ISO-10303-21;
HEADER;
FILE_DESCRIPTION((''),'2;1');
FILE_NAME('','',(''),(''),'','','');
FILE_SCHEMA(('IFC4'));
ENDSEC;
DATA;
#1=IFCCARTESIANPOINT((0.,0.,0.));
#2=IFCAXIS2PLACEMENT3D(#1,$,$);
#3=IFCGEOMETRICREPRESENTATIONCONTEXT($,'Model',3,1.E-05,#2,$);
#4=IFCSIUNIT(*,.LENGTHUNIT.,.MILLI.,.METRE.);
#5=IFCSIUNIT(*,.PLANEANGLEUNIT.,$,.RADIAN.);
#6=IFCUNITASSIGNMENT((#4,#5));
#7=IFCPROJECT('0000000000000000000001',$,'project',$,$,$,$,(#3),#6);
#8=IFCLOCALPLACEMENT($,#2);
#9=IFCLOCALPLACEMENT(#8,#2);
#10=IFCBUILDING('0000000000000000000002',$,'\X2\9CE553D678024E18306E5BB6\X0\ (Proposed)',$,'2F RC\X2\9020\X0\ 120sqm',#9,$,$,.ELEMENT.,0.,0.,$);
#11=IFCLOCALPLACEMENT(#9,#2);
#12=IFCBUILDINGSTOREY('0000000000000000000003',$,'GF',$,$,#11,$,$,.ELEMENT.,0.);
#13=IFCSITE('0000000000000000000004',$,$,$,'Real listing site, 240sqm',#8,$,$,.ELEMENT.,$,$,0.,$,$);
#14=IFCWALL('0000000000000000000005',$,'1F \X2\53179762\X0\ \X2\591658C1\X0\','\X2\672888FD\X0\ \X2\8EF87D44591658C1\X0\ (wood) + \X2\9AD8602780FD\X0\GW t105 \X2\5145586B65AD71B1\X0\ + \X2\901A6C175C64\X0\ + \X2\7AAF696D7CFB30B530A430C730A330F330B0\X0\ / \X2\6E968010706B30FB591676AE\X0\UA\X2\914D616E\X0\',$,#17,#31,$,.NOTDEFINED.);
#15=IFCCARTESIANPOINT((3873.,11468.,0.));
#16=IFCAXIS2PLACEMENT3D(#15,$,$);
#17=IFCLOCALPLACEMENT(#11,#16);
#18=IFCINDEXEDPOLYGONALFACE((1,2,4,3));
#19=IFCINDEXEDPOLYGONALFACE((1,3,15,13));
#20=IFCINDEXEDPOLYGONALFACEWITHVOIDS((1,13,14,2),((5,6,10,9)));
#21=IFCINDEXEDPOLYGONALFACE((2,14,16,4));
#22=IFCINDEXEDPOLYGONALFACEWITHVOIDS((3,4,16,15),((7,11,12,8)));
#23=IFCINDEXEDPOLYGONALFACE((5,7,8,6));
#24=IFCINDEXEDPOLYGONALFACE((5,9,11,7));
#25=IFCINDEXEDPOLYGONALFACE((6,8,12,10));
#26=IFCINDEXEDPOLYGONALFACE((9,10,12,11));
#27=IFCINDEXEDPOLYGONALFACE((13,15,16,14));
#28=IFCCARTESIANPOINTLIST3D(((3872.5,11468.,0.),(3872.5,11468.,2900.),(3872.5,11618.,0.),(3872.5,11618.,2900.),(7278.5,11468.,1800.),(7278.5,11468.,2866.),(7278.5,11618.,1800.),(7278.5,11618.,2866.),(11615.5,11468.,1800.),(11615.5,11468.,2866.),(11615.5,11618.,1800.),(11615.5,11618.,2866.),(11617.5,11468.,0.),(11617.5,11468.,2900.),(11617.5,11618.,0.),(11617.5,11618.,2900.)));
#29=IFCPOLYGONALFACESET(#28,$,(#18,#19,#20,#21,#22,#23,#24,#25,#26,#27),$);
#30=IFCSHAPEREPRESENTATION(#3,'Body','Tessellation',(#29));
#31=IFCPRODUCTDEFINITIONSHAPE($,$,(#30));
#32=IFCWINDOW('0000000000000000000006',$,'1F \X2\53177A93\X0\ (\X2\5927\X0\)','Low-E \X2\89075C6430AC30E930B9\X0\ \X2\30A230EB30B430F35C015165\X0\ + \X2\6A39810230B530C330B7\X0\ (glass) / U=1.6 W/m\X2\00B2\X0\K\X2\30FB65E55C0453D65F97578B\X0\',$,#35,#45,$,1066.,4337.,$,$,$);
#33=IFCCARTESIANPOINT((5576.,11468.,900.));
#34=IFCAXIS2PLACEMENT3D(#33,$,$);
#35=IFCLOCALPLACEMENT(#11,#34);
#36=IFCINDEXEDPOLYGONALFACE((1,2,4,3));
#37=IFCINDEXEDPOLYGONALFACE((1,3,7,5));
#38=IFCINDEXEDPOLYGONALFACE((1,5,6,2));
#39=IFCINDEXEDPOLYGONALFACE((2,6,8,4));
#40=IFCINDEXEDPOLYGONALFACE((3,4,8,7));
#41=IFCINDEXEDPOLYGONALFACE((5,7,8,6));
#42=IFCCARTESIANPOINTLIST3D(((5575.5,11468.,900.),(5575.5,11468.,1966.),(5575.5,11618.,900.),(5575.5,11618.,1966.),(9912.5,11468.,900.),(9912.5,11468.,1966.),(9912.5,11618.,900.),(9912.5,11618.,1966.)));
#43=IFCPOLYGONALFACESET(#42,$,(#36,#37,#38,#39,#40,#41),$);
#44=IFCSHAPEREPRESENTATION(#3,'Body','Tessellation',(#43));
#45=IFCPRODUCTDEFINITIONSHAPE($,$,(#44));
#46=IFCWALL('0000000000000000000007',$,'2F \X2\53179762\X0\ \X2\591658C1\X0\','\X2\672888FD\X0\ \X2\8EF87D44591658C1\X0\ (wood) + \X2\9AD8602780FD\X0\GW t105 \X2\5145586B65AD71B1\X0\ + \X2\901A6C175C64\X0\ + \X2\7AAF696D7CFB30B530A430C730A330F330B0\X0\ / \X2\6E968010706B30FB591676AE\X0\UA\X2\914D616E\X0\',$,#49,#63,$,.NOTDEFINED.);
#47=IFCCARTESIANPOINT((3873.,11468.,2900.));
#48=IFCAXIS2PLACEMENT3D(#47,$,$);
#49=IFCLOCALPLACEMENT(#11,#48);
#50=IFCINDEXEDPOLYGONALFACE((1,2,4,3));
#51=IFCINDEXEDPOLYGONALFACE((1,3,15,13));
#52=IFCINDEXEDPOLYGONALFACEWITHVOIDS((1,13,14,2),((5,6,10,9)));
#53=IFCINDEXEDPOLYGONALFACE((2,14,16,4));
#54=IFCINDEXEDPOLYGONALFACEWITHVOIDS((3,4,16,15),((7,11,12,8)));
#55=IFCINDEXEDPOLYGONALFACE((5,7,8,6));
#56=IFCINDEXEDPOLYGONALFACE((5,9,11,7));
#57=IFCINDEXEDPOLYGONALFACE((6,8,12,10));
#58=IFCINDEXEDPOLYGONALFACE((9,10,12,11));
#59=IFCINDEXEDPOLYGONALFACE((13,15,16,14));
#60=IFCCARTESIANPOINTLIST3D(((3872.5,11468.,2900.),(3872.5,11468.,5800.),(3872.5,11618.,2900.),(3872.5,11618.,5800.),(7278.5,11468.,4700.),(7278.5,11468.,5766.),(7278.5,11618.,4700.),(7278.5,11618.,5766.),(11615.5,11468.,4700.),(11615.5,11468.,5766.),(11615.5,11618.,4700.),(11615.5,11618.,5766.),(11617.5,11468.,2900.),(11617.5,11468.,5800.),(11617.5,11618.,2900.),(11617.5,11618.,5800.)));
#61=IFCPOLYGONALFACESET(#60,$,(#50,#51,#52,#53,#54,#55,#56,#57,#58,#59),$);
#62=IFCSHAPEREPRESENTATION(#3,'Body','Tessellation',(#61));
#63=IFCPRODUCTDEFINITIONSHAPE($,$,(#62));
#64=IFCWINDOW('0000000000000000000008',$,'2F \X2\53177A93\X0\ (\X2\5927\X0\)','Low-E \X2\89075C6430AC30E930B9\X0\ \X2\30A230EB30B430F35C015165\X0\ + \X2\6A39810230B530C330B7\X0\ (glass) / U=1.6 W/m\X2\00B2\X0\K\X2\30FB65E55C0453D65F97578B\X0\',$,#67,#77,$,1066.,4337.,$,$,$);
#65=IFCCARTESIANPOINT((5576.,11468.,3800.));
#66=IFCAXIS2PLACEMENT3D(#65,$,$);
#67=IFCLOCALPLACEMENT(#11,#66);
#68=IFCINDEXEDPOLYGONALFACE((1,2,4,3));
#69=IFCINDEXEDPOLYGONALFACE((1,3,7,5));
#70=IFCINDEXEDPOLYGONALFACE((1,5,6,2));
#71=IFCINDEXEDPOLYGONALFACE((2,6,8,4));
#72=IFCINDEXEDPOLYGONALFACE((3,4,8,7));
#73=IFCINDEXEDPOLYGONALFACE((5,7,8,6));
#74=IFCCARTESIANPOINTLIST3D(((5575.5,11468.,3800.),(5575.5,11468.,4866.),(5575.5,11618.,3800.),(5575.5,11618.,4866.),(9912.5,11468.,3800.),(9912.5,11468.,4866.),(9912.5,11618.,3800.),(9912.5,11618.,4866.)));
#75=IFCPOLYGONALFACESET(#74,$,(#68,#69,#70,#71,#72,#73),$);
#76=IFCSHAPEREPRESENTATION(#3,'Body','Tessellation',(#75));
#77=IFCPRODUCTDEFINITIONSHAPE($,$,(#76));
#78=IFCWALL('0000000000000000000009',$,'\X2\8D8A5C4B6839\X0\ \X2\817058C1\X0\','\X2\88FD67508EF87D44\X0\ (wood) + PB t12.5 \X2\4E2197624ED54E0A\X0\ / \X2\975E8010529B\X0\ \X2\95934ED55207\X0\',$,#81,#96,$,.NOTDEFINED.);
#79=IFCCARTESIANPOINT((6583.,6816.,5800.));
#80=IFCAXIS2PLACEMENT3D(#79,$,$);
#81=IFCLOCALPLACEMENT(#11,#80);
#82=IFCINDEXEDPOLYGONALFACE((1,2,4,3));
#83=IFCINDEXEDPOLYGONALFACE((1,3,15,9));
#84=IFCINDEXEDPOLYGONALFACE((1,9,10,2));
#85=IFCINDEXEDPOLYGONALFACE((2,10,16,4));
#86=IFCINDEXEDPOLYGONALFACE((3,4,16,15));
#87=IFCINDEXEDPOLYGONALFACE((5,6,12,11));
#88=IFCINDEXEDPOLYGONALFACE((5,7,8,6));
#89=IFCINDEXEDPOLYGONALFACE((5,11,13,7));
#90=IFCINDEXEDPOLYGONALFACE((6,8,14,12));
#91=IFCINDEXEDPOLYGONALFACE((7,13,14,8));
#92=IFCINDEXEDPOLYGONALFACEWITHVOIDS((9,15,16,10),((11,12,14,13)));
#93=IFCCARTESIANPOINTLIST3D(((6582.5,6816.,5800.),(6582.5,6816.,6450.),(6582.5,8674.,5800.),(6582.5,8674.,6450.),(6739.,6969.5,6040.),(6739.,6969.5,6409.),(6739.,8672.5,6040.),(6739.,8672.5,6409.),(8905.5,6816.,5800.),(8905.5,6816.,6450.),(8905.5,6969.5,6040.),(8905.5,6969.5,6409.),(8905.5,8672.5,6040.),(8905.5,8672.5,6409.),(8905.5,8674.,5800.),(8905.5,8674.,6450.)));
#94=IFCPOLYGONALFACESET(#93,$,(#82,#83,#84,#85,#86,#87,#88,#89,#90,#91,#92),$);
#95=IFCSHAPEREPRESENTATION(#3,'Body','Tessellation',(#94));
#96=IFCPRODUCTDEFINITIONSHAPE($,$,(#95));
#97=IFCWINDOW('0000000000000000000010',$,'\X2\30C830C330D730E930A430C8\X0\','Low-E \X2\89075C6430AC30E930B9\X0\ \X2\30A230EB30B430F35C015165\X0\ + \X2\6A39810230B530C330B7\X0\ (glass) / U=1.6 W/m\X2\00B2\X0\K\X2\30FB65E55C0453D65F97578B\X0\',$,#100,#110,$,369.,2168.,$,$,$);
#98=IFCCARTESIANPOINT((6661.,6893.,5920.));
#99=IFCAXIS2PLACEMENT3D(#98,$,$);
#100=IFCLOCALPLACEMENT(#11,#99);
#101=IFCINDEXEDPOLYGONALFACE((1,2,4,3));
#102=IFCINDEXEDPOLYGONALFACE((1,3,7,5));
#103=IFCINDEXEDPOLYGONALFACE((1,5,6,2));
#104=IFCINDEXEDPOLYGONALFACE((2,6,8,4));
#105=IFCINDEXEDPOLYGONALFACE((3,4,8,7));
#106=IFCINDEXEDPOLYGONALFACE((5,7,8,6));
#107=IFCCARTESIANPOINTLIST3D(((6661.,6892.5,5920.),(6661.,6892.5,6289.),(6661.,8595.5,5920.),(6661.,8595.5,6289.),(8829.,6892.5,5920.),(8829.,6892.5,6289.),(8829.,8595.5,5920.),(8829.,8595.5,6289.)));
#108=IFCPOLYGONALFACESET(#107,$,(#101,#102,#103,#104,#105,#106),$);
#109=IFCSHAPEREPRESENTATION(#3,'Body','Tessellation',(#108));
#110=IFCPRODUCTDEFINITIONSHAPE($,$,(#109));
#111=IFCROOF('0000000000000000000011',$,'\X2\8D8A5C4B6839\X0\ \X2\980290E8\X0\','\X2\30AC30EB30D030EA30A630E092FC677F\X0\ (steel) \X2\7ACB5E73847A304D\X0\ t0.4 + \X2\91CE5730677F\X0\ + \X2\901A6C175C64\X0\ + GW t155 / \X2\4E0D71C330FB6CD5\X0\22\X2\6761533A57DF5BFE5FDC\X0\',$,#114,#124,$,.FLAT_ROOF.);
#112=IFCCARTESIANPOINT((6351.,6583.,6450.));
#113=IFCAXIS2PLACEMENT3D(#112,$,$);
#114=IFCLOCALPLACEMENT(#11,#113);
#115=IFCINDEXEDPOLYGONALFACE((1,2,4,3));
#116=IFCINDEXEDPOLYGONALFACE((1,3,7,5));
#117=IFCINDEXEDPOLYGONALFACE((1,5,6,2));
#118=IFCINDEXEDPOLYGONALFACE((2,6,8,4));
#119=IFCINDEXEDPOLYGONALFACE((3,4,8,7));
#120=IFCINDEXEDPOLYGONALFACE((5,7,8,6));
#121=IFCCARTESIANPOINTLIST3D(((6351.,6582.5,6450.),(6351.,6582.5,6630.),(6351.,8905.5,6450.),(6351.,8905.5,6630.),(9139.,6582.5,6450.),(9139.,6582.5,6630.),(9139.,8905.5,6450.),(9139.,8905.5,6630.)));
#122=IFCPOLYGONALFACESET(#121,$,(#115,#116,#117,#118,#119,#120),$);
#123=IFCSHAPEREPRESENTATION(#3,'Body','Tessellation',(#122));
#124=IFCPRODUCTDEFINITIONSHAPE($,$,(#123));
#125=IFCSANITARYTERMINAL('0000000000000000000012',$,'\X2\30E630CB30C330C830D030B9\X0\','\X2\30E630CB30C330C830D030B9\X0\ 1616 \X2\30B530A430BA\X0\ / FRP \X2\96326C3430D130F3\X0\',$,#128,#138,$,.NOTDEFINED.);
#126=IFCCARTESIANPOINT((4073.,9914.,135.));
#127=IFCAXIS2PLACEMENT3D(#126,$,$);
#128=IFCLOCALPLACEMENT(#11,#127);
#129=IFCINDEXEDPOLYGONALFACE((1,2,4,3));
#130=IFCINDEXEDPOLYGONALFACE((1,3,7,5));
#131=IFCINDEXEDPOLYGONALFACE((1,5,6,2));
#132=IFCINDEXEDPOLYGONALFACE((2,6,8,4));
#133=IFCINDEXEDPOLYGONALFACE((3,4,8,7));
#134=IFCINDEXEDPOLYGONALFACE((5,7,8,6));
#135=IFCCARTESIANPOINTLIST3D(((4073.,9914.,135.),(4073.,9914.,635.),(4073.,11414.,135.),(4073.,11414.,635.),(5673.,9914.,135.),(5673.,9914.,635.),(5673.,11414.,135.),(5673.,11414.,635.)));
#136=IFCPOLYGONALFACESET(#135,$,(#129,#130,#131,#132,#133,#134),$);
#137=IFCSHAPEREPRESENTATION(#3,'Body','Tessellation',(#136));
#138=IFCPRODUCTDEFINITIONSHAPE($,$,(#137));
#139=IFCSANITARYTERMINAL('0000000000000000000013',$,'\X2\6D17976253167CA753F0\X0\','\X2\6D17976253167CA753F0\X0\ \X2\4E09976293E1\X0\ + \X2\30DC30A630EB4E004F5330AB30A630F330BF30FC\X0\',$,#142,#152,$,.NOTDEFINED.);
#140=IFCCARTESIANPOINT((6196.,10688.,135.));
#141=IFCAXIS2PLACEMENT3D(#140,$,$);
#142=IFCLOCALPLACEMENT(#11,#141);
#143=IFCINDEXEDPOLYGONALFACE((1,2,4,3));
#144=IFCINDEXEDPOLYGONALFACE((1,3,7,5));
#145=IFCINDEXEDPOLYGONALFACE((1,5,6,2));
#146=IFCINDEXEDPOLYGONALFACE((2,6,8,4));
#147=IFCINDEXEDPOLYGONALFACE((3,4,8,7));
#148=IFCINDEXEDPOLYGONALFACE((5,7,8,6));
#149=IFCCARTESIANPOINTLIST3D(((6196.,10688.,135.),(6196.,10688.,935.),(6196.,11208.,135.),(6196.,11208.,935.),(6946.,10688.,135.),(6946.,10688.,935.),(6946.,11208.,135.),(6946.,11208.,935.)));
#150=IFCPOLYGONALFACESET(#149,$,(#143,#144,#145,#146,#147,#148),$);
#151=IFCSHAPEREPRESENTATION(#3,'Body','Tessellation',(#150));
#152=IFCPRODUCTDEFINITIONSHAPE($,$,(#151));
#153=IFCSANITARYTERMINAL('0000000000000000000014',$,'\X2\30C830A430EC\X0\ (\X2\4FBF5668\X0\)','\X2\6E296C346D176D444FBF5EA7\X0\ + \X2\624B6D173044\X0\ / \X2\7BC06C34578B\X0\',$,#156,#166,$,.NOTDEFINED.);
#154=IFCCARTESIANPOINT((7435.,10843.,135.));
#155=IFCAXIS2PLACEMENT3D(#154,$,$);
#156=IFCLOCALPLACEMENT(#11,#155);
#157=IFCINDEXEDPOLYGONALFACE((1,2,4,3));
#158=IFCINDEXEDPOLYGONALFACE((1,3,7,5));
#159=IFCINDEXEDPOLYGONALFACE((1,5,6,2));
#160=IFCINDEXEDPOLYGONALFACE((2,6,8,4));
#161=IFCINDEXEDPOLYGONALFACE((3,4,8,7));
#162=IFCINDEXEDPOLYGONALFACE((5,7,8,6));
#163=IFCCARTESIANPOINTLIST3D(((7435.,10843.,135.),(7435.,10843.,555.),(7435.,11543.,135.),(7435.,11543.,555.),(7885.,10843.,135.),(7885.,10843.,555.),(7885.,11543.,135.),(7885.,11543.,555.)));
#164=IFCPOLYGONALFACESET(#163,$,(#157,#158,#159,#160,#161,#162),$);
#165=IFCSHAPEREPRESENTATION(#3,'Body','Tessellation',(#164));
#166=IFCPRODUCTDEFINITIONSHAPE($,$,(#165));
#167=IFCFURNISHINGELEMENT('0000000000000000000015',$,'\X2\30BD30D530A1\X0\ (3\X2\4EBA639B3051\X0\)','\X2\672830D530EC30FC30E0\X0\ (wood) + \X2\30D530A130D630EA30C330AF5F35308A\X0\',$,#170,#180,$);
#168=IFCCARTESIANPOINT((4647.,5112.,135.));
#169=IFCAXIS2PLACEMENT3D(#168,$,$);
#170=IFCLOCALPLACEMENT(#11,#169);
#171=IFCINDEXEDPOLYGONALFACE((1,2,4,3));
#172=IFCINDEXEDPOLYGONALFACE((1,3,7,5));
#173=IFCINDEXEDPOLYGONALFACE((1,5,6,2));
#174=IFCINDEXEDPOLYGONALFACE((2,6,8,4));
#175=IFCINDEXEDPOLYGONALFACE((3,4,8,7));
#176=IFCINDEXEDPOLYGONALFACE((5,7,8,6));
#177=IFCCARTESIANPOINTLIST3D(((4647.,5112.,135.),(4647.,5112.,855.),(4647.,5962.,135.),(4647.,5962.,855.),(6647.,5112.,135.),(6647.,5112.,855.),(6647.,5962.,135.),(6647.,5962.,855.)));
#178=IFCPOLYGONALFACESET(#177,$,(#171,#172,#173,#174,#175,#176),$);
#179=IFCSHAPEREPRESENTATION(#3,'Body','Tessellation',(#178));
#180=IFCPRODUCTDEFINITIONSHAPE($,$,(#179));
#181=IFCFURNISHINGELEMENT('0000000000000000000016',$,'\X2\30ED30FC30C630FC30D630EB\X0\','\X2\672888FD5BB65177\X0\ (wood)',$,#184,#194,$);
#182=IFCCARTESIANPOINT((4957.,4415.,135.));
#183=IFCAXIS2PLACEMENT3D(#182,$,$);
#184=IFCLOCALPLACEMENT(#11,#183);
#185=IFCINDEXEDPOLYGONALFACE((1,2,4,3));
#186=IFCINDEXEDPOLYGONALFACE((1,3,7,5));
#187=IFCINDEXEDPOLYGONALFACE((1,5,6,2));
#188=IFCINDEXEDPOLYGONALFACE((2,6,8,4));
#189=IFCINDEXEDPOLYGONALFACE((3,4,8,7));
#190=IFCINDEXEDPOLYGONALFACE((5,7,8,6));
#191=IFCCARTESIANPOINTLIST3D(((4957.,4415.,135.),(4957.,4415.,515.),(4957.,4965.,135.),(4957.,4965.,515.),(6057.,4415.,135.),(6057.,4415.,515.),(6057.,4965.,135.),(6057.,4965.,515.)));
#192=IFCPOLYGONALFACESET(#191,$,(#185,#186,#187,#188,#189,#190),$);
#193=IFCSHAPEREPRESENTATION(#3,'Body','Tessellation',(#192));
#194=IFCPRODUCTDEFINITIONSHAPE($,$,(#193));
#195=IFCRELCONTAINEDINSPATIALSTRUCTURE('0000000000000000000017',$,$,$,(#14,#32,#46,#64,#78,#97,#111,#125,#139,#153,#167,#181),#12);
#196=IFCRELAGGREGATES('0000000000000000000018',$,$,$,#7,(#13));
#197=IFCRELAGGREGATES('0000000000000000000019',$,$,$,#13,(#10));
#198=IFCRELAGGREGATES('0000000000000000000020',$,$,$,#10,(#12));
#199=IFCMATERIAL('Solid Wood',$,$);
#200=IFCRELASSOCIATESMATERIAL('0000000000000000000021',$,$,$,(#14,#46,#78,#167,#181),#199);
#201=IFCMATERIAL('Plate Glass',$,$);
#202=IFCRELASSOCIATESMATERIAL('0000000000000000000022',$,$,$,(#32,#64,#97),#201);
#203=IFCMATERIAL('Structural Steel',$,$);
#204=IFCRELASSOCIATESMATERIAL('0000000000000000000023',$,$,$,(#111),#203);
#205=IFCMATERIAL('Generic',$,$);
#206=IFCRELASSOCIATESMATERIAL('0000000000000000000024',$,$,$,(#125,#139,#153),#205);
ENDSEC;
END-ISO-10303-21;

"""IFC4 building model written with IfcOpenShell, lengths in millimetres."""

from ifc_helpers import new_model, si_unit, frame, frame_2d, origin, place, context, project, spatial, rectangle, extrude, material, element, fill, save


model = new_model("IFC4")

# Units and contexts
model_context = context("Model", 3, precision=1e-05, world=origin())
ifc_project = project(units=[si_unit("LENGTHUNIT", "METRE", prefix="MILLI"), si_unit("PLANEANGLEUNIT", "RADIAN")], contexts=[model_context])

# Site, building, storey
site_placement = place(None, origin())
site = spatial("IfcSite", under=ifc_project, at=site_placement, ObjectType="Real listing site, 240sqm", CompositionType="ELEMENT", RefElevation=0.0)
building_placement = place(site_placement, origin())
building = spatial("IfcBuilding", under=site, at=building_placement, Name="鳥取砂丘の家 (Proposed)", ObjectType="2F RC造 120sqm", CompositionType="ELEMENT", ElevationOfRefHeight=0.0, ElevationOfTerrain=0.0)
storey_placement = place(building_placement, origin())
storey = spatial("IfcBuildingStorey", under=building, at=storey_placement, Name="GF", CompositionType="ELEMENT", Elevation=0.0)

# Wall, opening, window
ifc_material_1 = material(Name="Solid Wood")
wall_1_placement = place(storey_placement, frame((3873.0, 11468.0, 0.0)))
wall_1 = element("IfcWall", 1, at=wall_1_placement, inside=storey, material=ifc_material_1, Name="1F 北面 外壁", Description="木製 軸組外壁 (wood) + 高性能GW t105 充填断熱 + 通気層 + 窯業系サイディング / 準耐火・外皮UA配慮", PredefinedType="NOTDEFINED", context=model_context, shape_type="SweptSolid", body=[
    extrude(rectangle(XDim=7745.0, YDim=150.0, at=frame_2d((3872.0, 75.0))), frame((3873.0, 11468.0, 0.0)), (0.0, 0.0, 1.0), 2900.0),
])
opening_1_placement = place(storey_placement, frame((5576.0, 11468.0, 900.0)))
opening_1 = element("IfcOpeningElement", 2, at=opening_1_placement, cuts=wall_1, PredefinedType="NOTDEFINED", context=model_context, shape_type="SweptSolid", body=[
    extrude(rectangle(XDim=4337.0, YDim=150.0, at=frame_2d((2168.0, 75.0))), frame((5576.0, 11468.0, 900.0)), (0.0, 0.0, 1.0), 1066.0),
])
ifc_material_2 = material(Name="Plate Glass")
window_1_placement = place(storey_placement, frame((5576.0, 11468.0, 900.0)))
window_1 = element("IfcWindow", 3, at=window_1_placement, inside=storey, material=ifc_material_2, Name="1F 北窓 (大)", Description="Low-E 複層ガラス アルゴン封入 + 樹脂サッシ (glass) / U=1.6 W/m²K・日射取得型", OverallHeight=1066.0, OverallWidth=4337.0, context=model_context, shape_type="SweptSolid", body=[
    extrude(rectangle(XDim=4337.0, YDim=150.0, at=frame_2d((2168.0, 75.0))), frame((5576.0, 11468.0, 900.0)), (0.0, 0.0, 1.0), 1066.0),
])
fill(opening_1, window_1)

# Wall, opening, window
wall_2_placement = place(storey_placement, frame((3873.0, 11468.0, 2900.0)))
wall_2 = element("IfcWall", 4, at=wall_2_placement, inside=storey, material=ifc_material_1, Name="2F 北面 外壁", Description="木製 軸組外壁 (wood) + 高性能GW t105 充填断熱 + 通気層 + 窯業系サイディング / 準耐火・外皮UA配慮", PredefinedType="NOTDEFINED", context=model_context, shape_type="SweptSolid", body=[
    extrude(rectangle(XDim=7745.0, YDim=150.0, at=frame_2d((3872.0, 75.0))), frame((3873.0, 11468.0, 2900.0)), (0.0, 0.0, 1.0), 2900.0),
])
opening_2_placement = place(storey_placement, frame((5576.0, 11468.0, 3800.0)))
opening_2 = element("IfcOpeningElement", 5, at=opening_2_placement, cuts=wall_2, PredefinedType="NOTDEFINED", context=model_context, shape_type="SweptSolid", body=[
    extrude(rectangle(XDim=4337.0, YDim=150.0, at=frame_2d((2168.0, 75.0))), frame((5576.0, 11468.0, 3800.0)), (0.0, 0.0, 1.0), 1066.0),
])
window_2_placement = place(storey_placement, frame((5576.0, 11468.0, 3800.0)))
window_2 = element("IfcWindow", 6, at=window_2_placement, inside=storey, material=ifc_material_2, Name="2F 北窓 (大)", Description="Low-E 複層ガラス アルゴン封入 + 樹脂サッシ (glass) / U=1.6 W/m²K・日射取得型", OverallHeight=1066.0, OverallWidth=4337.0, context=model_context, shape_type="SweptSolid", body=[
    extrude(rectangle(XDim=4337.0, YDim=150.0, at=frame_2d((2168.0, 75.0))), frame((5576.0, 11468.0, 3800.0)), (0.0, 0.0, 1.0), 1066.0),
])
fill(opening_2, window_2)

# Wall, opening, window
wall_3_placement = place(storey_placement, frame((6583.0, 6816.0, 5800.0)))
wall_3 = element("IfcWall", 7, at=wall_3_placement, inside=storey, material=ifc_material_1, Name="越屋根 腰壁", Description="製材軸組 (wood) + PB t12.5 両面仕上 / 非耐力 間仕切", PredefinedType="NOTDEFINED", context=model_context, shape_type="SweptSolid", body=[
    extrude(rectangle(XDim=2323.0, YDim=1858.0, at=frame_2d((1161.0, 929.0))), frame((6583.0, 6816.0, 5800.0)), (0.0, 0.0, 1.0), 650.0),
])
opening_3_placement = place(storey_placement, frame((6661.0, 6893.0, 5920.0)))
opening_3 = element("IfcOpeningElement", 8, at=opening_3_placement, cuts=wall_3, PredefinedType="NOTDEFINED", context=model_context, shape_type="SweptSolid", body=[
    extrude(rectangle(XDim=2168.0, YDim=1703.0, at=frame_2d((1084.0, 851.0))), frame((6661.0, 6893.0, 5920.0)), (0.0, 0.0, 1.0), 369.0),
])
window_3_placement = place(storey_placement, frame((6661.0, 6893.0, 5920.0)))
window_3 = element("IfcWindow", 9, at=window_3_placement, inside=storey, material=ifc_material_2, Name="トップライト", Description="Low-E 複層ガラス アルゴン封入 + 樹脂サッシ (glass) / U=1.6 W/m²K・日射取得型", OverallHeight=369.0, OverallWidth=2168.0, context=model_context, shape_type="SweptSolid", body=[
    extrude(rectangle(XDim=2168.0, YDim=1703.0, at=frame_2d((1084.0, 851.0))), frame((6661.0, 6893.0, 5920.0)), (0.0, 0.0, 1.0), 369.0),
])
fill(opening_3, window_3)

# Roof
ifc_material_3 = material(Name="Structural Steel")
roof_placement = place(storey_placement, frame((6351.0, 6583.0, 6450.0)))
element("IfcRoof", 10, at=roof_placement, inside=storey, material=ifc_material_3, Name="越屋根 頂部", Description="ガルバリウム鋼板 (steel) 立平葺き t0.4 + 野地板 + 通気層 + GW t155 / 不燃・法22条区域対応", PredefinedType="FLAT_ROOF", context=model_context, shape_type="SweptSolid", body=[
    extrude(rectangle(XDim=2788.0, YDim=2323.0, at=frame_2d((1394.0, 1161.0))), frame((6351.0, 6583.0, 6450.0)), (0.0, 0.0, 1.0), 180.0),
])

# Sanitary terminals
ifc_material_4 = material(Name="Generic")
sanitary_terminal_1_placement = place(storey_placement, frame((4073.0, 9914.0, 135.0)))
element("IfcSanitaryTerminal", 11, at=sanitary_terminal_1_placement, inside=storey, material=ifc_material_4, Name="ユニットバス", Description="ユニットバス 1616 サイズ / FRP 防水パン", PredefinedType="NOTDEFINED", context=model_context, shape_type="SweptSolid", body=[
    extrude(rectangle(XDim=1600.0, YDim=1500.0, at=frame_2d((800.0, 750.0))), frame((4073.0, 9914.0, 135.0)), (0.0, 0.0, 1.0), 500.0),
])
sanitary_terminal_2_placement = place(storey_placement, frame((6196.0, 10688.0, 135.0)))
element("IfcSanitaryTerminal", 12, at=sanitary_terminal_2_placement, inside=storey, material=ifc_material_4, Name="洗面化粧台", Description="洗面化粧台 三面鏡 + ボウル一体カウンター", PredefinedType="NOTDEFINED", context=model_context, shape_type="SweptSolid", body=[
    extrude(rectangle(XDim=750.0, YDim=520.0, at=frame_2d((375.0, 260.0))), frame((6196.0, 10688.0, 135.0)), (0.0, 0.0, 1.0), 800.0),
])
sanitary_terminal_3_placement = place(storey_placement, frame((7435.0, 10843.0, 135.0)))
element("IfcSanitaryTerminal", 13, at=sanitary_terminal_3_placement, inside=storey, material=ifc_material_4, Name="トイレ (便器)", Description="温水洗浄便座 + 手洗い / 節水型", PredefinedType="NOTDEFINED", context=model_context, shape_type="SweptSolid", body=[
    extrude(rectangle(XDim=450.0, YDim=700.0, at=frame_2d((225.0, 350.0))), frame((7435.0, 10843.0, 135.0)), (0.0, 0.0, 1.0), 420.0),
])

# Furnishing elements
furnishing_1_placement = place(storey_placement, frame((4647.0, 5112.0, 135.0)))
element("IfcFurnishingElement", 14, at=furnishing_1_placement, inside=storey, material=ifc_material_1, Name="ソファ (3人掛け)", Description="木フレーム (wood) + ファブリック張り", context=model_context, shape_type="SweptSolid", body=[
    extrude(rectangle(XDim=2000.0, YDim=850.0, at=frame_2d((1000.0, 425.0))), frame((4647.0, 5112.0, 135.0)), (0.0, 0.0, 1.0), 720.0),
])
furnishing_2_placement = place(storey_placement, frame((4957.0, 4415.0, 135.0)))
element("IfcFurnishingElement", 15, at=furnishing_2_placement, inside=storey, material=ifc_material_1, Name="ローテーブル", Description="木製家具 (wood)", context=model_context, shape_type="SweptSolid", body=[
    extrude(rectangle(XDim=1100.0, YDim=550.0, at=frame_2d((550.0, 275.0))), frame((4957.0, 4415.0, 135.0)), (0.0, 0.0, 1.0), 380.0),
])

save(model, "model.ifc")
